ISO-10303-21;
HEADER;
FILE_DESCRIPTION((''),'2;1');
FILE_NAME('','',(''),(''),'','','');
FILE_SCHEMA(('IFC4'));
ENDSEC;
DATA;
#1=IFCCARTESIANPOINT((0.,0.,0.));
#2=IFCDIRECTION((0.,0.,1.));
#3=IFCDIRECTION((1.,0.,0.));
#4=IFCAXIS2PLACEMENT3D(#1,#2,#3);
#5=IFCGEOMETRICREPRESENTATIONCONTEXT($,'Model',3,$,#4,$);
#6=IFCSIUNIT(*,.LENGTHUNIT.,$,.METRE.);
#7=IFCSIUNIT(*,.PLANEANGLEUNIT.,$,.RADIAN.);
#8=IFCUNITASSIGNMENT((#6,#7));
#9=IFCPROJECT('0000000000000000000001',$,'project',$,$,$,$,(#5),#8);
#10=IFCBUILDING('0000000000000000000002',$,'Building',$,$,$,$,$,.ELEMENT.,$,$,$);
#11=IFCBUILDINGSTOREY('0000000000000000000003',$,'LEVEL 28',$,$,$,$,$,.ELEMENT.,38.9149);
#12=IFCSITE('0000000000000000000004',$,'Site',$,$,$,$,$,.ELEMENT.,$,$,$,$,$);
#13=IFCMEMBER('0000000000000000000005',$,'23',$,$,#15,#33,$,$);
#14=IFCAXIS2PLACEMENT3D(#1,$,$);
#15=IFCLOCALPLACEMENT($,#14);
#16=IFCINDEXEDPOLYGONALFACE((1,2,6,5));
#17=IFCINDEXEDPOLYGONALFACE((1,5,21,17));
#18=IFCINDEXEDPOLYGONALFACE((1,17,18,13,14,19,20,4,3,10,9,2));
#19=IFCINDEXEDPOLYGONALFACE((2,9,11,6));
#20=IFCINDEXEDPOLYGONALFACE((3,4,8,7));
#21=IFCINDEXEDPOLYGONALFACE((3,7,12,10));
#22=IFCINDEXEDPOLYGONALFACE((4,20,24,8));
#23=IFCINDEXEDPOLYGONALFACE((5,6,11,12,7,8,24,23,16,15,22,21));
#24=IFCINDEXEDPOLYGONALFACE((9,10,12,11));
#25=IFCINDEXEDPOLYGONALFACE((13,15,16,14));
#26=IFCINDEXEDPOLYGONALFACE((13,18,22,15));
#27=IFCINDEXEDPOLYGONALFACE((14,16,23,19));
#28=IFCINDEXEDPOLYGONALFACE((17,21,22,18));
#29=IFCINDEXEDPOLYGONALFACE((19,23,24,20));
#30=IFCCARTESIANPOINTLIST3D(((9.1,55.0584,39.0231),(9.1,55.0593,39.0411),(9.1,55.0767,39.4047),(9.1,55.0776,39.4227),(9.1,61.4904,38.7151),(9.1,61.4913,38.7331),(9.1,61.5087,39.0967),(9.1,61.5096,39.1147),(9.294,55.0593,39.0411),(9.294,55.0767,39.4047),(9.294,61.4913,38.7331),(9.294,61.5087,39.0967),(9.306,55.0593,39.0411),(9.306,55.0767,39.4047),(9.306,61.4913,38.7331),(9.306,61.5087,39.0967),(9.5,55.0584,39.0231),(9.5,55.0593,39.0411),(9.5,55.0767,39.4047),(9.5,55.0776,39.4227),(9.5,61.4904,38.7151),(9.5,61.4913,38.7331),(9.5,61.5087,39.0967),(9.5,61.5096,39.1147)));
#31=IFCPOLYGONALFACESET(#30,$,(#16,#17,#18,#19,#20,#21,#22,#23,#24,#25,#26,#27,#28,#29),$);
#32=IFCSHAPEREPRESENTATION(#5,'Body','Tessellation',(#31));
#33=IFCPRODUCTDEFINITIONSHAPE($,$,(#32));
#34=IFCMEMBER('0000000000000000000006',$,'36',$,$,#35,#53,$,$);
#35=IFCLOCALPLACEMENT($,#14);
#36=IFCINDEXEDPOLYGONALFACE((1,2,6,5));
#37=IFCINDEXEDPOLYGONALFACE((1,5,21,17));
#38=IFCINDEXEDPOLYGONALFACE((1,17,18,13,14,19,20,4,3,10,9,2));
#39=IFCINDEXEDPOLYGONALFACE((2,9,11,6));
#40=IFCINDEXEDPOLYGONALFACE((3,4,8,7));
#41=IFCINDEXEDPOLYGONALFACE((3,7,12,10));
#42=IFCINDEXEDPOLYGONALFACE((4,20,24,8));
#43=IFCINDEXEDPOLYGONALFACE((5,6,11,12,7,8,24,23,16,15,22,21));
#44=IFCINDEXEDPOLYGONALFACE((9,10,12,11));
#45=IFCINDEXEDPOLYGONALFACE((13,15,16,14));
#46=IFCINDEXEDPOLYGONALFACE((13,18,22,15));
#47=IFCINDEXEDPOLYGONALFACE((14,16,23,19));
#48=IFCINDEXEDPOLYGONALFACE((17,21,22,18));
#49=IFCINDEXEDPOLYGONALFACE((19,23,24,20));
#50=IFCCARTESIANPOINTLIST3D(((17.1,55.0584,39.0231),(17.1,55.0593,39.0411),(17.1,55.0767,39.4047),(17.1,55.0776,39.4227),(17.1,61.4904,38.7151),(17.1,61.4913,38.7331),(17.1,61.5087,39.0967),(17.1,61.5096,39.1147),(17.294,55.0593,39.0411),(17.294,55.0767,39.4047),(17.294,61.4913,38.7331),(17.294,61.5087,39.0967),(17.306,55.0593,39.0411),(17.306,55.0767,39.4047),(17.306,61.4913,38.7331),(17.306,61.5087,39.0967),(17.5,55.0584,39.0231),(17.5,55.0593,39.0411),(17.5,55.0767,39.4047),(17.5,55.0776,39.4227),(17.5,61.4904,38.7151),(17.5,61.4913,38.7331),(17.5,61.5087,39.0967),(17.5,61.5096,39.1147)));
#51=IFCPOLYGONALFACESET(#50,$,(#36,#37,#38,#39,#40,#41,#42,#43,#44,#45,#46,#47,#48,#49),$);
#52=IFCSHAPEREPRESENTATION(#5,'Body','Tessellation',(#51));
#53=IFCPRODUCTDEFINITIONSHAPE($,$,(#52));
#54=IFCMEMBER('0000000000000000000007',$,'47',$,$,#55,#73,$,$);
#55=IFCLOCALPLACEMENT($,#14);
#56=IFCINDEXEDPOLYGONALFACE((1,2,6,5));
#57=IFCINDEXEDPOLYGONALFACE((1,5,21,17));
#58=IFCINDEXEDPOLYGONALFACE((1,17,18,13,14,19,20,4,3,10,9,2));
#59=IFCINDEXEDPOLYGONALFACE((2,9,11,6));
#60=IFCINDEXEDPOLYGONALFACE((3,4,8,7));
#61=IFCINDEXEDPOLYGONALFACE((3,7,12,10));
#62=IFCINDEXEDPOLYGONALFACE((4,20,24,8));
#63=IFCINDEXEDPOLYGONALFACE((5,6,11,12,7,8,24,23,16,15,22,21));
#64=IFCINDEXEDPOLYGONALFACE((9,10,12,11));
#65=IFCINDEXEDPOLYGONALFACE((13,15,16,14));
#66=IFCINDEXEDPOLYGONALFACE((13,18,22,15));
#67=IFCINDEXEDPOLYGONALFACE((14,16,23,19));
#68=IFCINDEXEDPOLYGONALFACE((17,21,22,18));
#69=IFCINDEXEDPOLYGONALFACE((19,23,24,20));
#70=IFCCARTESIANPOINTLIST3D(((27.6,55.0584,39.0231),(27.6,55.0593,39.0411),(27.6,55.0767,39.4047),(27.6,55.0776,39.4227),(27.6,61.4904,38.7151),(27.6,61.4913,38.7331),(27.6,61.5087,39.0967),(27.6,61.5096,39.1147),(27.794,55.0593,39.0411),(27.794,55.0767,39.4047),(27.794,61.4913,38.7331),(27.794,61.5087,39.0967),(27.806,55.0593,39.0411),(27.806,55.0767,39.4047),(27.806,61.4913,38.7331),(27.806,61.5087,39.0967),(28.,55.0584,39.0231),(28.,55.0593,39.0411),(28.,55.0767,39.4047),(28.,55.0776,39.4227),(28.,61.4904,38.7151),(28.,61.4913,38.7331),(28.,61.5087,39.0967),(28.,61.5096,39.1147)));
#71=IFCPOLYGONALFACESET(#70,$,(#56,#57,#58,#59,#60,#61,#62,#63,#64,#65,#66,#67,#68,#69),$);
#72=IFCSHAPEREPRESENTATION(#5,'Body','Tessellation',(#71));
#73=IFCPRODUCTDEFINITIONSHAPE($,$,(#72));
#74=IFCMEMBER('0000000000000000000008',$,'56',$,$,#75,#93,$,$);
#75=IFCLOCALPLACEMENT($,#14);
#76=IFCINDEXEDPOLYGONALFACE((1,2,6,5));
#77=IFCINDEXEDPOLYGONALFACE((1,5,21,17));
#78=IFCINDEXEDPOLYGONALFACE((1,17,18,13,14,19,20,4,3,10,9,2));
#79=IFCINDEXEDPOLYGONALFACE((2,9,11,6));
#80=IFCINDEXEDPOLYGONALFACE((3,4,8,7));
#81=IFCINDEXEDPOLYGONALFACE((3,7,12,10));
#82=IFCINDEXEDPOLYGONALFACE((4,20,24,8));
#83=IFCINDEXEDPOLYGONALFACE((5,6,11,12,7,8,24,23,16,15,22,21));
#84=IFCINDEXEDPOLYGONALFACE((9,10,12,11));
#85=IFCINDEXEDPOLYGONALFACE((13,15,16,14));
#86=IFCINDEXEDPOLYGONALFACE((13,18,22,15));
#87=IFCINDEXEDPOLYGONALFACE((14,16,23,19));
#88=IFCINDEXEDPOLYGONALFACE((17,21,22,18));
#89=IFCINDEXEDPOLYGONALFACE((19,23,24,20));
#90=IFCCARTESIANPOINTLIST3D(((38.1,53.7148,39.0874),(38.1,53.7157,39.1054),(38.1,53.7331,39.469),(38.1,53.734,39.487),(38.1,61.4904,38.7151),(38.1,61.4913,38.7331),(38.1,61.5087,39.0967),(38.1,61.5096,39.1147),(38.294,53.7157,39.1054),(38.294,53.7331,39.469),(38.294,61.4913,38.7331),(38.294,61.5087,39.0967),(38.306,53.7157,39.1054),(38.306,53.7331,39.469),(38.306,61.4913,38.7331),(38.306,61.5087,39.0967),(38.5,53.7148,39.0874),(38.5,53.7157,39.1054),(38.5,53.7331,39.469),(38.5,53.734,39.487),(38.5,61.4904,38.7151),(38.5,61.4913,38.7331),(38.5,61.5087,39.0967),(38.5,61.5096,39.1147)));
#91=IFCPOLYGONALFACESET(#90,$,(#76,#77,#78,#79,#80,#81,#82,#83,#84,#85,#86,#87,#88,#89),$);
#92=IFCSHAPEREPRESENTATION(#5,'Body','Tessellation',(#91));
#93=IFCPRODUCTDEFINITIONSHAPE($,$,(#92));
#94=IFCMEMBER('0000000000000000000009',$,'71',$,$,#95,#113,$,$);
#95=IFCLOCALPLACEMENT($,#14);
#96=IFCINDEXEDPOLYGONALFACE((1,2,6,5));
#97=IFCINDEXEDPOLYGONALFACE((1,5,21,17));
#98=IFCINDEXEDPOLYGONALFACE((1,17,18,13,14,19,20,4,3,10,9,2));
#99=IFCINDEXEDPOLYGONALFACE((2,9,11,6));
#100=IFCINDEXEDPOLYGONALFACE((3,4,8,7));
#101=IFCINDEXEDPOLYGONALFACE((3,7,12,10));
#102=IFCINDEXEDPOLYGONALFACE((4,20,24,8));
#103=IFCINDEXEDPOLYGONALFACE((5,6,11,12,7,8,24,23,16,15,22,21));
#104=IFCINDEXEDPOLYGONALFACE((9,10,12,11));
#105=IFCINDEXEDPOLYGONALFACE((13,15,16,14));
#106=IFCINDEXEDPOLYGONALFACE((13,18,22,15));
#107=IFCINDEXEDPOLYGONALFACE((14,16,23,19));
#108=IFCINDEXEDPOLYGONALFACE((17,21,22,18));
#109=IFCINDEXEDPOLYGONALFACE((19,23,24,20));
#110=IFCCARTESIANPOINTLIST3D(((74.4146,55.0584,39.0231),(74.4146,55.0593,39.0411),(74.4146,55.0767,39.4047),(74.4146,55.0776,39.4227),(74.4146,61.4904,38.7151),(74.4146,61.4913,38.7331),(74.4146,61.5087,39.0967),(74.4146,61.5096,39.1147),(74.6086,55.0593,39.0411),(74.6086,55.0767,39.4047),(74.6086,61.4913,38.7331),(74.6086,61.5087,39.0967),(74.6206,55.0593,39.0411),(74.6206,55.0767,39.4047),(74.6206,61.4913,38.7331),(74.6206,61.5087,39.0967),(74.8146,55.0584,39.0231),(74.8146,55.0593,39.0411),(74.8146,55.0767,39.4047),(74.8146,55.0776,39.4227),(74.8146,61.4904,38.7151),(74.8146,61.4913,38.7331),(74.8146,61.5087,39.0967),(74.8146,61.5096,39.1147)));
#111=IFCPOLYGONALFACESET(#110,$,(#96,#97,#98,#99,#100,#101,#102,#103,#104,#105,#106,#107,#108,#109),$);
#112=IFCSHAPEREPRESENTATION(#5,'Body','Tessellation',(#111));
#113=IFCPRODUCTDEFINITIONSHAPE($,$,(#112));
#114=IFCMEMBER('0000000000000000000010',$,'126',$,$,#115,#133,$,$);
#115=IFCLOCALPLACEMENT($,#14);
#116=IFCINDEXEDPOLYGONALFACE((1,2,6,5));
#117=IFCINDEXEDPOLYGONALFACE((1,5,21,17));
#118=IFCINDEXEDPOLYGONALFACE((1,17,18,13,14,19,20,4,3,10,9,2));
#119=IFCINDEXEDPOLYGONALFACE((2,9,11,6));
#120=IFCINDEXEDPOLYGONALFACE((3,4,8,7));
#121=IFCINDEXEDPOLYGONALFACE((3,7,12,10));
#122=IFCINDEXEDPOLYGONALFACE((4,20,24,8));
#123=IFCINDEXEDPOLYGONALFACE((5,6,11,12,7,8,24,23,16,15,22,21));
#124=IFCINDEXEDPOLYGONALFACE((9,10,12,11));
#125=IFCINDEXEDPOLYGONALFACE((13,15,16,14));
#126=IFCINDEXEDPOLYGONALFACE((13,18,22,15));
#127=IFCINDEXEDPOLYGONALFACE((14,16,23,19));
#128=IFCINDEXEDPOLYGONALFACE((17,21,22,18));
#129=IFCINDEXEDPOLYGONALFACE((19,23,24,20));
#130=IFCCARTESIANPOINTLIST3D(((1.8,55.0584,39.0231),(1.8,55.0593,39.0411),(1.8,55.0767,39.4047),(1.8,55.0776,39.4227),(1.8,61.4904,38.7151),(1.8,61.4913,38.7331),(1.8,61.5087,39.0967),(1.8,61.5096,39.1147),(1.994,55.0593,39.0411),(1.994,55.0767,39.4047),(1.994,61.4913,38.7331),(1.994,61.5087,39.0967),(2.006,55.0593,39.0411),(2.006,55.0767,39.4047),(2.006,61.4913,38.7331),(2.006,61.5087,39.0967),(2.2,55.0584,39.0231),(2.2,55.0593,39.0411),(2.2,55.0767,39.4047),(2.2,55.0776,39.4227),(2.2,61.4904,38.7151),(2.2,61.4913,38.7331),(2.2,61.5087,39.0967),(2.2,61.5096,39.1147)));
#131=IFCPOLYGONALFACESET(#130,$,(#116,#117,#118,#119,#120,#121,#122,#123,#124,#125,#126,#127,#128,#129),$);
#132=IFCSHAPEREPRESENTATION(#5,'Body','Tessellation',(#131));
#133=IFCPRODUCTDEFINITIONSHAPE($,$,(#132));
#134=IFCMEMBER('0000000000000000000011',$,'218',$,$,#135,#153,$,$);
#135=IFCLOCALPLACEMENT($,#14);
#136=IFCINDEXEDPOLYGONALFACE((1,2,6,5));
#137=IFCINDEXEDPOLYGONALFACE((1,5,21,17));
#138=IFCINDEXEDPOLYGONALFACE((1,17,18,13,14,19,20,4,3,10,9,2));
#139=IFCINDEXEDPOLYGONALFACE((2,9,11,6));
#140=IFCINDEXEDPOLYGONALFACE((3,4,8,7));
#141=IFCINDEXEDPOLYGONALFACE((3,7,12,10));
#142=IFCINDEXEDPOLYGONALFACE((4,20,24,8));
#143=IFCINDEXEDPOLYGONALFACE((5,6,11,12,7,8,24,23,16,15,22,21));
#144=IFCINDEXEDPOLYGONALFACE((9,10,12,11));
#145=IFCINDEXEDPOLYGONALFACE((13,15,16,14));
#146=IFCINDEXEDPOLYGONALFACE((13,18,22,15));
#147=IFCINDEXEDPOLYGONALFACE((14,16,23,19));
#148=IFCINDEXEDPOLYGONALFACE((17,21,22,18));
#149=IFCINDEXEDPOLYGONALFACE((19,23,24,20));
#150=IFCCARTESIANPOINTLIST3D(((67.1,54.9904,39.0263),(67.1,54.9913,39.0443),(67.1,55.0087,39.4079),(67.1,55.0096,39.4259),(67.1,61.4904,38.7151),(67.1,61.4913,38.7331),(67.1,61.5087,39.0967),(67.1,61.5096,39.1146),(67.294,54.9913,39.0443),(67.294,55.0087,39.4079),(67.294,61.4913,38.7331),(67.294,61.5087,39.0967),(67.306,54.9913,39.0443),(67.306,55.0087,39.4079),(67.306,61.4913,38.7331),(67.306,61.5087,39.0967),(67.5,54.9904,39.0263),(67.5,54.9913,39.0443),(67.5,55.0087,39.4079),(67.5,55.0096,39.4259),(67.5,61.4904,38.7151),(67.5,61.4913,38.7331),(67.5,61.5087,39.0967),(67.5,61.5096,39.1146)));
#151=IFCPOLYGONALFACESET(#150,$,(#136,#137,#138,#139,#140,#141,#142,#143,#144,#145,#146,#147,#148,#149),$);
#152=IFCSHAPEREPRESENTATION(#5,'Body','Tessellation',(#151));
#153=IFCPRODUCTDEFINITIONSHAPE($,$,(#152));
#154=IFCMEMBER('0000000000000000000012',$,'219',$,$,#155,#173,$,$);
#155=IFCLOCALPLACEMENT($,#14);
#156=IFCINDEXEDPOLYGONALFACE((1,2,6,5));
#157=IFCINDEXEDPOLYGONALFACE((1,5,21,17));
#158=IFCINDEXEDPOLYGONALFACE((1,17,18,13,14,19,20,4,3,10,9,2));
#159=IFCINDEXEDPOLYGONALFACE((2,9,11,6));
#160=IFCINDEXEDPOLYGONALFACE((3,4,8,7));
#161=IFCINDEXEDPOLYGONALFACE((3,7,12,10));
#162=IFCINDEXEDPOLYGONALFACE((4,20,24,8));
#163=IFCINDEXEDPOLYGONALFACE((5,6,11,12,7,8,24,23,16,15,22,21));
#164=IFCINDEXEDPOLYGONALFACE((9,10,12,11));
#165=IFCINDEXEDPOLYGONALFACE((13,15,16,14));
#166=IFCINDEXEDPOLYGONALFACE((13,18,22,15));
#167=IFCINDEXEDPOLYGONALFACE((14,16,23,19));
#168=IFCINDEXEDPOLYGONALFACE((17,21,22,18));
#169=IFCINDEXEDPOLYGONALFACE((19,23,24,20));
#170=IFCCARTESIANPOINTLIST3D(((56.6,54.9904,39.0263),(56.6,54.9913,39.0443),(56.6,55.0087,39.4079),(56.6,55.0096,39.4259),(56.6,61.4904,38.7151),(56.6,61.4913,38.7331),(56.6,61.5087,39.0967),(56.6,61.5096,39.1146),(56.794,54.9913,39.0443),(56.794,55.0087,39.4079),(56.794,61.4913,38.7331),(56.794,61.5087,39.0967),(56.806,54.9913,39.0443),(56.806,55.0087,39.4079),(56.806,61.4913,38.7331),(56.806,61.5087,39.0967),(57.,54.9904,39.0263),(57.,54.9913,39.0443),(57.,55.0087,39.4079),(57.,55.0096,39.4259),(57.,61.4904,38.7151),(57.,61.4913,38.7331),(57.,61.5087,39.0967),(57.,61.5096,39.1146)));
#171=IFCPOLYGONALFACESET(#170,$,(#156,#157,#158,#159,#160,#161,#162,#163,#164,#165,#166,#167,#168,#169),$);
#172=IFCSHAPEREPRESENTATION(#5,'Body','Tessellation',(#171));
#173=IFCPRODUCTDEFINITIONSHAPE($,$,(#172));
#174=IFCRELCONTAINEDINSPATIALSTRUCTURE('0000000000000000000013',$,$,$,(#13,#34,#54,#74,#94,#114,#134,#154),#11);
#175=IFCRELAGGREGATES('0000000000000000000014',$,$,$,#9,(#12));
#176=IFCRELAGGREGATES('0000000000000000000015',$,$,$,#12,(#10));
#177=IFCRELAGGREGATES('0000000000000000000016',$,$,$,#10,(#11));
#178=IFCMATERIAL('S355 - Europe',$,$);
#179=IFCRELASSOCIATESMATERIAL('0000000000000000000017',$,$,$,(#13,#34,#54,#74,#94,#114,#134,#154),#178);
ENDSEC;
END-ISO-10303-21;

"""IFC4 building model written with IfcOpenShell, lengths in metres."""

from ifc_helpers import new_model, si_unit, frame, origin_with_axes, origin_2d_with_axis, place, context, project, spatial, i_section, extrude, material, material_profile, profile_set, profile_usage, element, save


model = new_model("IFC4")

# Units and contexts
model_context = context("Model", 3, world=origin_with_axes())
ifc_project = project(units=[si_unit("LENGTHUNIT", "METRE"), si_unit("PLANEANGLEUNIT", "RADIAN")], contexts=[model_context])

# Site, building, storey
site = spatial("IfcSite", under=ifc_project, Name="Site", CompositionType="ELEMENT")
building = spatial("IfcBuilding", under=site, Name="Building", CompositionType="ELEMENT")
storey = spatial("IfcBuildingStorey", under=building, Name="LEVEL 28", CompositionType="ELEMENT", Elevation=38.9149)

# Shared definitions
ifc_material = material(Name="S355 - Europe")

# Members
ifc_material_profile_1 = material_profile(ifc_material, i_section(OverallWidth=0.4, OverallDepth=0.4, WebThickness=0.012, FlangeThickness=0.018, at=origin_2d_with_axis()))
ifc_profile_set_1 = profile_set([ifc_material_profile_1])
ifc_profile_usage_1 = profile_usage(ifc_profile_set_1, cardinal=10)
member_1_placement = place(None, frame((9.3, 61.5, 38.9149), z_axis=(0.0, -0.998856, 0.047828), x_axis=(1.0, 0.0, 0.0)))
element("IfcMember", 1, at=member_1_placement, inside=storey, material=ifc_profile_usage_1, Name="23", context=model_context, shape_type="SweptSolid", body=[
    extrude(i_section(OverallWidth=0.4, OverallDepth=0.4, WebThickness=0.012, FlangeThickness=0.018, at=origin_2d_with_axis()), origin_with_axes(), (0.0, 0.0, 1.0), 6.4394),
])
ifc_material_profile_2 = material_profile(ifc_material, i_section(OverallWidth=0.4, OverallDepth=0.4, WebThickness=0.012, FlangeThickness=0.018, at=origin_2d_with_axis()))
ifc_profile_set_2 = profile_set([ifc_material_profile_2])
ifc_profile_usage_2 = profile_usage(ifc_profile_set_2, cardinal=10)
member_2_placement = place(None, frame((17.3, 61.5, 38.9149), z_axis=(0.0, -0.998856, 0.047828), x_axis=(1.0, 0.0, 0.0)))
element("IfcMember", 2, at=member_2_placement, inside=storey, material=ifc_profile_usage_2, Name="36", context=model_context, shape_type="SweptSolid", body=[
    extrude(i_section(OverallWidth=0.4, OverallDepth=0.4, WebThickness=0.012, FlangeThickness=0.018, at=origin_2d_with_axis()), origin_with_axes(), (0.0, 0.0, 1.0), 6.4394),
])
ifc_material_profile_3 = material_profile(ifc_material, i_section(OverallWidth=0.4, OverallDepth=0.4, WebThickness=0.012, FlangeThickness=0.018, at=origin_2d_with_axis()))
ifc_profile_set_3 = profile_set([ifc_material_profile_3])
ifc_profile_usage_3 = profile_usage(ifc_profile_set_3, cardinal=10)
member_3_placement = place(None, frame((27.8, 61.5, 38.9149), z_axis=(0.0, -0.998856, 0.047828), x_axis=(1.0, 0.0, 0.0)))
element("IfcMember", 3, at=member_3_placement, inside=storey, material=ifc_profile_usage_3, Name="47", context=model_context, shape_type="SweptSolid", body=[
    extrude(i_section(OverallWidth=0.4, OverallDepth=0.4, WebThickness=0.012, FlangeThickness=0.018, at=origin_2d_with_axis()), origin_with_axes(), (0.0, 0.0, 1.0), 6.4394),
])
ifc_material_profile_4 = material_profile(ifc_material, i_section(OverallWidth=0.4, OverallDepth=0.4, WebThickness=0.012, FlangeThickness=0.018, at=origin_2d_with_axis()))
ifc_profile_set_4 = profile_set([ifc_material_profile_4])
ifc_profile_usage_4 = profile_usage(ifc_profile_set_4, cardinal=10)
member_4_placement = place(None, frame((38.3, 61.5, 38.9149), z_axis=(0.0, -0.998856, 0.047828), x_axis=(1.0, 0.0, 0.0)))
element("IfcMember", 4, at=member_4_placement, inside=storey, material=ifc_profile_usage_4, Name="56", context=model_context, shape_type="SweptSolid", body=[
    extrude(i_section(OverallWidth=0.4, OverallDepth=0.4, WebThickness=0.012, FlangeThickness=0.018, at=origin_2d_with_axis()), origin_with_axes(), (0.0, 0.0, 1.0), 7.7845),
])
ifc_material_profile_5 = material_profile(ifc_material, i_section(OverallWidth=0.4, OverallDepth=0.4, WebThickness=0.012, FlangeThickness=0.018, at=origin_2d_with_axis()))
ifc_profile_set_5 = profile_set([ifc_material_profile_5])
ifc_profile_usage_5 = profile_usage(ifc_profile_set_5, cardinal=10)
member_5_placement = place(None, frame((74.6146, 61.5, 38.9149), z_axis=(0.0, -0.998856, 0.047828), x_axis=(1.0, 0.0, 0.0)))
element("IfcMember", 5, at=member_5_placement, inside=storey, material=ifc_profile_usage_5, Name="71", context=model_context, shape_type="SweptSolid", body=[
    extrude(i_section(OverallWidth=0.4, OverallDepth=0.4, WebThickness=0.012, FlangeThickness=0.018, at=origin_2d_with_axis()), origin_with_axes(), (0.0, 0.0, 1.0), 6.4394),
])
ifc_material_profile_6 = material_profile(ifc_material, i_section(OverallWidth=0.4, OverallDepth=0.4, WebThickness=0.012, FlangeThickness=0.018, at=origin_2d_with_axis()))
ifc_profile_set_6 = profile_set([ifc_material_profile_6])
ifc_profile_usage_6 = profile_usage(ifc_profile_set_6, cardinal=10)
member_6_placement = place(None, frame((2.0, 61.5, 38.9149), z_axis=(0.0, -0.998856, 0.047828), x_axis=(1.0, 0.0, 0.0)))
element("IfcMember", 6, at=member_6_placement, inside=storey, material=ifc_profile_usage_6, Name="126", context=model_context, shape_type="SweptSolid", body=[
    extrude(i_section(OverallWidth=0.4, OverallDepth=0.4, WebThickness=0.012, FlangeThickness=0.018, at=origin_2d_with_axis()), origin_with_axes(), (0.0, 0.0, 1.0), 6.4394),
])
ifc_material_profile_7 = material_profile(ifc_material, i_section(OverallWidth=0.4, OverallDepth=0.4, WebThickness=0.012, FlangeThickness=0.018, at=origin_2d_with_axis()))
ifc_profile_set_7 = profile_set([ifc_material_profile_7])
ifc_profile_usage_7 = profile_usage(ifc_profile_set_7, cardinal=10)
member_7_placement = place(None, frame((67.3, 55.0, 39.2261), z_axis=(0.0, 0.998856, -0.047828), x_axis=(-1.0, 0.0, 0.0)))
element("IfcMember", 7, at=member_7_placement, inside=storey, material=ifc_profile_usage_7, Name="218", context=model_context, shape_type="SweptSolid", body=[
    extrude(i_section(OverallWidth=0.4, OverallDepth=0.4, WebThickness=0.012, FlangeThickness=0.018, at=origin_2d_with_axis()), origin_with_axes(), (0.0, 0.0, 1.0), 6.5074),
])
ifc_material_profile_8 = material_profile(ifc_material, i_section(OverallWidth=0.4, OverallDepth=0.4, WebThickness=0.012, FlangeThickness=0.018, at=origin_2d_with_axis()))
ifc_profile_set_8 = profile_set([ifc_material_profile_8])
ifc_profile_usage_8 = profile_usage(ifc_profile_set_8, cardinal=10)
member_8_placement = place(None, frame((56.8, 55.0, 39.2261), z_axis=(0.0, 0.998856, -0.047828), x_axis=(-1.0, 0.0, 0.0)))
element("IfcMember", 8, at=member_8_placement, inside=storey, material=ifc_profile_usage_8, Name="219", context=model_context, shape_type="SweptSolid", body=[
    extrude(i_section(OverallWidth=0.4, OverallDepth=0.4, WebThickness=0.012, FlangeThickness=0.018, at=origin_2d_with_axis()), origin_with_axes(), (0.0, 0.0, 1.0), 6.5074),
])

save(model, "model.ifc")
